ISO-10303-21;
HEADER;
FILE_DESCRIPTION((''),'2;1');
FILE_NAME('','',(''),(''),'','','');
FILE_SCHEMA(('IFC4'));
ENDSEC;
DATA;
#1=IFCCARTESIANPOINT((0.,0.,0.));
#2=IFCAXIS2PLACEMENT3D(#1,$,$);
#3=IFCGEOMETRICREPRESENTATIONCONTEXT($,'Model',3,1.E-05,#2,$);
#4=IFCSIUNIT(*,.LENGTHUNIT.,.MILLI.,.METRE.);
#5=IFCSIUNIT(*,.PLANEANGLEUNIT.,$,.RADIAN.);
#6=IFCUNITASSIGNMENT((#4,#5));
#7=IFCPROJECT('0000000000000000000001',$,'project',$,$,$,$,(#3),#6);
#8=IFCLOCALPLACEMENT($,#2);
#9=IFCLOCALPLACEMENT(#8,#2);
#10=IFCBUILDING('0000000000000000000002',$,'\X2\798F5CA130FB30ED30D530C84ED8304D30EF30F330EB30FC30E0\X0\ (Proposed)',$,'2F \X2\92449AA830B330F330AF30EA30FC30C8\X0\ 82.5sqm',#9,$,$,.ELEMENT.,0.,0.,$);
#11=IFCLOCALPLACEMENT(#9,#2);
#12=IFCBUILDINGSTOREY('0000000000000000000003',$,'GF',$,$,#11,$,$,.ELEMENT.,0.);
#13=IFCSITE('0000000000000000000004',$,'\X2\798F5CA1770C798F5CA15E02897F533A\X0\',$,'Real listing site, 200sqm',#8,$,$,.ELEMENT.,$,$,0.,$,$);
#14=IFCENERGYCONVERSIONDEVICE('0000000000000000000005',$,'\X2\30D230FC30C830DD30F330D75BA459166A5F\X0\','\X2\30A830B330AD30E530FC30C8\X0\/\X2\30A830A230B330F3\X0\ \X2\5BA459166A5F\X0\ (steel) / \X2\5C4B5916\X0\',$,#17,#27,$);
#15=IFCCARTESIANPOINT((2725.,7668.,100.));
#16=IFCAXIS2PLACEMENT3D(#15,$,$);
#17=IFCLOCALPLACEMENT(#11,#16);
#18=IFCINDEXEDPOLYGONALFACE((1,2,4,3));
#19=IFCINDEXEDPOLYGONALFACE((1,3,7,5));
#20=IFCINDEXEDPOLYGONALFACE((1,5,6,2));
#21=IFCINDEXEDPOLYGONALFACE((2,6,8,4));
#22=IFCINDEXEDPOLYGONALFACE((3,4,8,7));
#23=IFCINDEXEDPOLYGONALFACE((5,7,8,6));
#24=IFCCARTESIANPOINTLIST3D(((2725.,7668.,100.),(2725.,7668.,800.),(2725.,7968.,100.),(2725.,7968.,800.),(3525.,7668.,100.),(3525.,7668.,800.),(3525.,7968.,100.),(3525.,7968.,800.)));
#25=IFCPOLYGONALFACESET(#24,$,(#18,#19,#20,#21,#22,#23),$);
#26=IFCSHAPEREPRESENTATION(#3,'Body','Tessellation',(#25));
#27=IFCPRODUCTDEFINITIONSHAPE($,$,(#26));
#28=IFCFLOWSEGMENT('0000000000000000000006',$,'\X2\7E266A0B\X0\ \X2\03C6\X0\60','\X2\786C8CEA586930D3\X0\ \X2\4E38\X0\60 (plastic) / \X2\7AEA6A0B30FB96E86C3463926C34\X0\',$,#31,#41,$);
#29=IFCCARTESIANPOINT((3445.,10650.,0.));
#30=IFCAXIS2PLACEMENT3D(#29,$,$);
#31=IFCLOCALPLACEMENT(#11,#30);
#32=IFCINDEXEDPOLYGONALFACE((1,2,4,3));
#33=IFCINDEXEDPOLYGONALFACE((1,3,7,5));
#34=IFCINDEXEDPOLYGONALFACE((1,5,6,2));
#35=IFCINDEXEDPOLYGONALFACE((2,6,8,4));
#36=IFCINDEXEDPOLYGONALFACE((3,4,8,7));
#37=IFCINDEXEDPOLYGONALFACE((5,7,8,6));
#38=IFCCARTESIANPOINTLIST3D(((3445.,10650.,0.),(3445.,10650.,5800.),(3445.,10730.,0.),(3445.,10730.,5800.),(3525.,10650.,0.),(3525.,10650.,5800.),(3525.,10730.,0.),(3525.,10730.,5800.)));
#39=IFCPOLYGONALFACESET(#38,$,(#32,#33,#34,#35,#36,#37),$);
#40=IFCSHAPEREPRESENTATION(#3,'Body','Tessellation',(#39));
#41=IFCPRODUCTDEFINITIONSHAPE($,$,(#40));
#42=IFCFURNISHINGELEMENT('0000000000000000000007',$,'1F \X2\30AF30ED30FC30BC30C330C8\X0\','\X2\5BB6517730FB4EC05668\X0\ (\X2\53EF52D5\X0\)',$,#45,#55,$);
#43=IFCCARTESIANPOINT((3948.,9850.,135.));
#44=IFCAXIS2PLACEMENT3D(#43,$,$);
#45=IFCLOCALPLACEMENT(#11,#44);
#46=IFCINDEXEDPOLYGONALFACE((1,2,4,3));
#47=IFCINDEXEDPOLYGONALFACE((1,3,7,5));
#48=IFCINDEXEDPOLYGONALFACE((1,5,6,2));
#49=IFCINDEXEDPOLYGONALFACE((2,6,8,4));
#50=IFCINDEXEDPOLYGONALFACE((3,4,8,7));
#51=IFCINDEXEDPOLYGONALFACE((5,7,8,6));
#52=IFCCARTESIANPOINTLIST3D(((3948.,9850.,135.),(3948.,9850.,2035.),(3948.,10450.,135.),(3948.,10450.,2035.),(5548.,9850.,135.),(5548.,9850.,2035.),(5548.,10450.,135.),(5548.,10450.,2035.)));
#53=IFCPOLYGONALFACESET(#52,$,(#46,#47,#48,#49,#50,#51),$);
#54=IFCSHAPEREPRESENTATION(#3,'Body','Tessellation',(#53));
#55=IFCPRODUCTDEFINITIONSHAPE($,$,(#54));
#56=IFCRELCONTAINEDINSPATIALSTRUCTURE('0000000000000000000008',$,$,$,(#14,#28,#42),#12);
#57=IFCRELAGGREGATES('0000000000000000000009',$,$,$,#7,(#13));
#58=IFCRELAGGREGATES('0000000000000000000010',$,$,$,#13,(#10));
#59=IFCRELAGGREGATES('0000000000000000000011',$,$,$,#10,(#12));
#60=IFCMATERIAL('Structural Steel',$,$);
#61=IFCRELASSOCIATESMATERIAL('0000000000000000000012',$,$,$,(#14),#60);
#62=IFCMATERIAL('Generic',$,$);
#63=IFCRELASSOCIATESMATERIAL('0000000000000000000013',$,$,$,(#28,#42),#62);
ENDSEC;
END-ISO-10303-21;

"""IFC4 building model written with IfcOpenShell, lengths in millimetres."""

from ifc_helpers import new_model, si_unit, frame, frame_2d, origin, place, context, project, spatial, rectangle, extrude, material, element, save


model = new_model("IFC4")

# Units and contexts
model_context = context("Model", 3, precision=1e-05, world=origin())
ifc_project = project(units=[si_unit("LENGTHUNIT", "METRE", prefix="MILLI"), si_unit("PLANEANGLEUNIT", "RADIAN")], contexts=[model_context])

# Site, building, storey
site_placement = place(None, origin())
site = spatial("IfcSite", under=ifc_project, at=site_placement, Name="福岡県福岡市西区", ObjectType="Real listing site, 200sqm", CompositionType="ELEMENT", RefElevation=0.0)
building_placement = place(site_placement, origin())
building = spatial("IfcBuilding", under=site, at=building_placement, Name="福岡・ロフト付きワンルーム (Proposed)", ObjectType="2F 鉄骨コンクリート 82.5sqm", CompositionType="ELEMENT", ElevationOfRefHeight=0.0, ElevationOfTerrain=0.0)
storey_placement = place(building_placement, origin())
storey = spatial("IfcBuildingStorey", under=building, at=storey_placement, Name="GF", CompositionType="ELEMENT", Elevation=0.0)

# Shared definitions
ifc_material_1 = material(Name="Generic")

# Energy conversion device
ifc_material_2 = material(Name="Structural Steel")
energy_conversion_device_placement = place(storey_placement, frame((2725.0, 7668.0, 100.0)))
element("IfcEnergyConversionDevice", 1, at=energy_conversion_device_placement, inside=storey, material=ifc_material_2, Name="ヒートポンプ室外機", Description="エコキュート/エアコン 室外機 (steel) / 屋外", context=model_context, shape_type="SweptSolid", body=[
    extrude(rectangle(XDim=800.0, YDim=300.0, at=frame_2d((400.0, 150.0))), frame((2725.0, 7668.0, 100.0)), (0.0, 0.0, 1.0), 700.0),
])

# Flow segment
flow_segment_placement = place(storey_placement, frame((3445.0, 10650.0, 0.0)))
element("IfcFlowSegment", 2, at=flow_segment_placement, inside=storey, material=ifc_material_1, Name="縦樋 φ60", Description="硬質塩ビ 丸60 (plastic) / 竪樋・雨水排水", context=model_context, shape_type="SweptSolid", body=[
    extrude(rectangle(XDim=80.0, YDim=80.0, at=frame_2d((40.0, 40.0))), frame((3445.0, 10650.0, 0.0)), (0.0, 0.0, 1.0), 5800.0),
])

# Furnishing element
furnishing_placement = place(storey_placement, frame((3948.0, 9850.0, 135.0)))
element("IfcFurnishingElement", 3, at=furnishing_placement, inside=storey, material=ifc_material_1, Name="1F クローゼット", Description="家具・什器 (可動)", context=model_context, shape_type="SweptSolid", body=[
    extrude(rectangle(XDim=1600.0, YDim=600.0, at=frame_2d((800.0, 300.0))), frame((3948.0, 9850.0, 135.0)), (0.0, 0.0, 1.0), 1900.0),
])

save(model, "model.ifc")
